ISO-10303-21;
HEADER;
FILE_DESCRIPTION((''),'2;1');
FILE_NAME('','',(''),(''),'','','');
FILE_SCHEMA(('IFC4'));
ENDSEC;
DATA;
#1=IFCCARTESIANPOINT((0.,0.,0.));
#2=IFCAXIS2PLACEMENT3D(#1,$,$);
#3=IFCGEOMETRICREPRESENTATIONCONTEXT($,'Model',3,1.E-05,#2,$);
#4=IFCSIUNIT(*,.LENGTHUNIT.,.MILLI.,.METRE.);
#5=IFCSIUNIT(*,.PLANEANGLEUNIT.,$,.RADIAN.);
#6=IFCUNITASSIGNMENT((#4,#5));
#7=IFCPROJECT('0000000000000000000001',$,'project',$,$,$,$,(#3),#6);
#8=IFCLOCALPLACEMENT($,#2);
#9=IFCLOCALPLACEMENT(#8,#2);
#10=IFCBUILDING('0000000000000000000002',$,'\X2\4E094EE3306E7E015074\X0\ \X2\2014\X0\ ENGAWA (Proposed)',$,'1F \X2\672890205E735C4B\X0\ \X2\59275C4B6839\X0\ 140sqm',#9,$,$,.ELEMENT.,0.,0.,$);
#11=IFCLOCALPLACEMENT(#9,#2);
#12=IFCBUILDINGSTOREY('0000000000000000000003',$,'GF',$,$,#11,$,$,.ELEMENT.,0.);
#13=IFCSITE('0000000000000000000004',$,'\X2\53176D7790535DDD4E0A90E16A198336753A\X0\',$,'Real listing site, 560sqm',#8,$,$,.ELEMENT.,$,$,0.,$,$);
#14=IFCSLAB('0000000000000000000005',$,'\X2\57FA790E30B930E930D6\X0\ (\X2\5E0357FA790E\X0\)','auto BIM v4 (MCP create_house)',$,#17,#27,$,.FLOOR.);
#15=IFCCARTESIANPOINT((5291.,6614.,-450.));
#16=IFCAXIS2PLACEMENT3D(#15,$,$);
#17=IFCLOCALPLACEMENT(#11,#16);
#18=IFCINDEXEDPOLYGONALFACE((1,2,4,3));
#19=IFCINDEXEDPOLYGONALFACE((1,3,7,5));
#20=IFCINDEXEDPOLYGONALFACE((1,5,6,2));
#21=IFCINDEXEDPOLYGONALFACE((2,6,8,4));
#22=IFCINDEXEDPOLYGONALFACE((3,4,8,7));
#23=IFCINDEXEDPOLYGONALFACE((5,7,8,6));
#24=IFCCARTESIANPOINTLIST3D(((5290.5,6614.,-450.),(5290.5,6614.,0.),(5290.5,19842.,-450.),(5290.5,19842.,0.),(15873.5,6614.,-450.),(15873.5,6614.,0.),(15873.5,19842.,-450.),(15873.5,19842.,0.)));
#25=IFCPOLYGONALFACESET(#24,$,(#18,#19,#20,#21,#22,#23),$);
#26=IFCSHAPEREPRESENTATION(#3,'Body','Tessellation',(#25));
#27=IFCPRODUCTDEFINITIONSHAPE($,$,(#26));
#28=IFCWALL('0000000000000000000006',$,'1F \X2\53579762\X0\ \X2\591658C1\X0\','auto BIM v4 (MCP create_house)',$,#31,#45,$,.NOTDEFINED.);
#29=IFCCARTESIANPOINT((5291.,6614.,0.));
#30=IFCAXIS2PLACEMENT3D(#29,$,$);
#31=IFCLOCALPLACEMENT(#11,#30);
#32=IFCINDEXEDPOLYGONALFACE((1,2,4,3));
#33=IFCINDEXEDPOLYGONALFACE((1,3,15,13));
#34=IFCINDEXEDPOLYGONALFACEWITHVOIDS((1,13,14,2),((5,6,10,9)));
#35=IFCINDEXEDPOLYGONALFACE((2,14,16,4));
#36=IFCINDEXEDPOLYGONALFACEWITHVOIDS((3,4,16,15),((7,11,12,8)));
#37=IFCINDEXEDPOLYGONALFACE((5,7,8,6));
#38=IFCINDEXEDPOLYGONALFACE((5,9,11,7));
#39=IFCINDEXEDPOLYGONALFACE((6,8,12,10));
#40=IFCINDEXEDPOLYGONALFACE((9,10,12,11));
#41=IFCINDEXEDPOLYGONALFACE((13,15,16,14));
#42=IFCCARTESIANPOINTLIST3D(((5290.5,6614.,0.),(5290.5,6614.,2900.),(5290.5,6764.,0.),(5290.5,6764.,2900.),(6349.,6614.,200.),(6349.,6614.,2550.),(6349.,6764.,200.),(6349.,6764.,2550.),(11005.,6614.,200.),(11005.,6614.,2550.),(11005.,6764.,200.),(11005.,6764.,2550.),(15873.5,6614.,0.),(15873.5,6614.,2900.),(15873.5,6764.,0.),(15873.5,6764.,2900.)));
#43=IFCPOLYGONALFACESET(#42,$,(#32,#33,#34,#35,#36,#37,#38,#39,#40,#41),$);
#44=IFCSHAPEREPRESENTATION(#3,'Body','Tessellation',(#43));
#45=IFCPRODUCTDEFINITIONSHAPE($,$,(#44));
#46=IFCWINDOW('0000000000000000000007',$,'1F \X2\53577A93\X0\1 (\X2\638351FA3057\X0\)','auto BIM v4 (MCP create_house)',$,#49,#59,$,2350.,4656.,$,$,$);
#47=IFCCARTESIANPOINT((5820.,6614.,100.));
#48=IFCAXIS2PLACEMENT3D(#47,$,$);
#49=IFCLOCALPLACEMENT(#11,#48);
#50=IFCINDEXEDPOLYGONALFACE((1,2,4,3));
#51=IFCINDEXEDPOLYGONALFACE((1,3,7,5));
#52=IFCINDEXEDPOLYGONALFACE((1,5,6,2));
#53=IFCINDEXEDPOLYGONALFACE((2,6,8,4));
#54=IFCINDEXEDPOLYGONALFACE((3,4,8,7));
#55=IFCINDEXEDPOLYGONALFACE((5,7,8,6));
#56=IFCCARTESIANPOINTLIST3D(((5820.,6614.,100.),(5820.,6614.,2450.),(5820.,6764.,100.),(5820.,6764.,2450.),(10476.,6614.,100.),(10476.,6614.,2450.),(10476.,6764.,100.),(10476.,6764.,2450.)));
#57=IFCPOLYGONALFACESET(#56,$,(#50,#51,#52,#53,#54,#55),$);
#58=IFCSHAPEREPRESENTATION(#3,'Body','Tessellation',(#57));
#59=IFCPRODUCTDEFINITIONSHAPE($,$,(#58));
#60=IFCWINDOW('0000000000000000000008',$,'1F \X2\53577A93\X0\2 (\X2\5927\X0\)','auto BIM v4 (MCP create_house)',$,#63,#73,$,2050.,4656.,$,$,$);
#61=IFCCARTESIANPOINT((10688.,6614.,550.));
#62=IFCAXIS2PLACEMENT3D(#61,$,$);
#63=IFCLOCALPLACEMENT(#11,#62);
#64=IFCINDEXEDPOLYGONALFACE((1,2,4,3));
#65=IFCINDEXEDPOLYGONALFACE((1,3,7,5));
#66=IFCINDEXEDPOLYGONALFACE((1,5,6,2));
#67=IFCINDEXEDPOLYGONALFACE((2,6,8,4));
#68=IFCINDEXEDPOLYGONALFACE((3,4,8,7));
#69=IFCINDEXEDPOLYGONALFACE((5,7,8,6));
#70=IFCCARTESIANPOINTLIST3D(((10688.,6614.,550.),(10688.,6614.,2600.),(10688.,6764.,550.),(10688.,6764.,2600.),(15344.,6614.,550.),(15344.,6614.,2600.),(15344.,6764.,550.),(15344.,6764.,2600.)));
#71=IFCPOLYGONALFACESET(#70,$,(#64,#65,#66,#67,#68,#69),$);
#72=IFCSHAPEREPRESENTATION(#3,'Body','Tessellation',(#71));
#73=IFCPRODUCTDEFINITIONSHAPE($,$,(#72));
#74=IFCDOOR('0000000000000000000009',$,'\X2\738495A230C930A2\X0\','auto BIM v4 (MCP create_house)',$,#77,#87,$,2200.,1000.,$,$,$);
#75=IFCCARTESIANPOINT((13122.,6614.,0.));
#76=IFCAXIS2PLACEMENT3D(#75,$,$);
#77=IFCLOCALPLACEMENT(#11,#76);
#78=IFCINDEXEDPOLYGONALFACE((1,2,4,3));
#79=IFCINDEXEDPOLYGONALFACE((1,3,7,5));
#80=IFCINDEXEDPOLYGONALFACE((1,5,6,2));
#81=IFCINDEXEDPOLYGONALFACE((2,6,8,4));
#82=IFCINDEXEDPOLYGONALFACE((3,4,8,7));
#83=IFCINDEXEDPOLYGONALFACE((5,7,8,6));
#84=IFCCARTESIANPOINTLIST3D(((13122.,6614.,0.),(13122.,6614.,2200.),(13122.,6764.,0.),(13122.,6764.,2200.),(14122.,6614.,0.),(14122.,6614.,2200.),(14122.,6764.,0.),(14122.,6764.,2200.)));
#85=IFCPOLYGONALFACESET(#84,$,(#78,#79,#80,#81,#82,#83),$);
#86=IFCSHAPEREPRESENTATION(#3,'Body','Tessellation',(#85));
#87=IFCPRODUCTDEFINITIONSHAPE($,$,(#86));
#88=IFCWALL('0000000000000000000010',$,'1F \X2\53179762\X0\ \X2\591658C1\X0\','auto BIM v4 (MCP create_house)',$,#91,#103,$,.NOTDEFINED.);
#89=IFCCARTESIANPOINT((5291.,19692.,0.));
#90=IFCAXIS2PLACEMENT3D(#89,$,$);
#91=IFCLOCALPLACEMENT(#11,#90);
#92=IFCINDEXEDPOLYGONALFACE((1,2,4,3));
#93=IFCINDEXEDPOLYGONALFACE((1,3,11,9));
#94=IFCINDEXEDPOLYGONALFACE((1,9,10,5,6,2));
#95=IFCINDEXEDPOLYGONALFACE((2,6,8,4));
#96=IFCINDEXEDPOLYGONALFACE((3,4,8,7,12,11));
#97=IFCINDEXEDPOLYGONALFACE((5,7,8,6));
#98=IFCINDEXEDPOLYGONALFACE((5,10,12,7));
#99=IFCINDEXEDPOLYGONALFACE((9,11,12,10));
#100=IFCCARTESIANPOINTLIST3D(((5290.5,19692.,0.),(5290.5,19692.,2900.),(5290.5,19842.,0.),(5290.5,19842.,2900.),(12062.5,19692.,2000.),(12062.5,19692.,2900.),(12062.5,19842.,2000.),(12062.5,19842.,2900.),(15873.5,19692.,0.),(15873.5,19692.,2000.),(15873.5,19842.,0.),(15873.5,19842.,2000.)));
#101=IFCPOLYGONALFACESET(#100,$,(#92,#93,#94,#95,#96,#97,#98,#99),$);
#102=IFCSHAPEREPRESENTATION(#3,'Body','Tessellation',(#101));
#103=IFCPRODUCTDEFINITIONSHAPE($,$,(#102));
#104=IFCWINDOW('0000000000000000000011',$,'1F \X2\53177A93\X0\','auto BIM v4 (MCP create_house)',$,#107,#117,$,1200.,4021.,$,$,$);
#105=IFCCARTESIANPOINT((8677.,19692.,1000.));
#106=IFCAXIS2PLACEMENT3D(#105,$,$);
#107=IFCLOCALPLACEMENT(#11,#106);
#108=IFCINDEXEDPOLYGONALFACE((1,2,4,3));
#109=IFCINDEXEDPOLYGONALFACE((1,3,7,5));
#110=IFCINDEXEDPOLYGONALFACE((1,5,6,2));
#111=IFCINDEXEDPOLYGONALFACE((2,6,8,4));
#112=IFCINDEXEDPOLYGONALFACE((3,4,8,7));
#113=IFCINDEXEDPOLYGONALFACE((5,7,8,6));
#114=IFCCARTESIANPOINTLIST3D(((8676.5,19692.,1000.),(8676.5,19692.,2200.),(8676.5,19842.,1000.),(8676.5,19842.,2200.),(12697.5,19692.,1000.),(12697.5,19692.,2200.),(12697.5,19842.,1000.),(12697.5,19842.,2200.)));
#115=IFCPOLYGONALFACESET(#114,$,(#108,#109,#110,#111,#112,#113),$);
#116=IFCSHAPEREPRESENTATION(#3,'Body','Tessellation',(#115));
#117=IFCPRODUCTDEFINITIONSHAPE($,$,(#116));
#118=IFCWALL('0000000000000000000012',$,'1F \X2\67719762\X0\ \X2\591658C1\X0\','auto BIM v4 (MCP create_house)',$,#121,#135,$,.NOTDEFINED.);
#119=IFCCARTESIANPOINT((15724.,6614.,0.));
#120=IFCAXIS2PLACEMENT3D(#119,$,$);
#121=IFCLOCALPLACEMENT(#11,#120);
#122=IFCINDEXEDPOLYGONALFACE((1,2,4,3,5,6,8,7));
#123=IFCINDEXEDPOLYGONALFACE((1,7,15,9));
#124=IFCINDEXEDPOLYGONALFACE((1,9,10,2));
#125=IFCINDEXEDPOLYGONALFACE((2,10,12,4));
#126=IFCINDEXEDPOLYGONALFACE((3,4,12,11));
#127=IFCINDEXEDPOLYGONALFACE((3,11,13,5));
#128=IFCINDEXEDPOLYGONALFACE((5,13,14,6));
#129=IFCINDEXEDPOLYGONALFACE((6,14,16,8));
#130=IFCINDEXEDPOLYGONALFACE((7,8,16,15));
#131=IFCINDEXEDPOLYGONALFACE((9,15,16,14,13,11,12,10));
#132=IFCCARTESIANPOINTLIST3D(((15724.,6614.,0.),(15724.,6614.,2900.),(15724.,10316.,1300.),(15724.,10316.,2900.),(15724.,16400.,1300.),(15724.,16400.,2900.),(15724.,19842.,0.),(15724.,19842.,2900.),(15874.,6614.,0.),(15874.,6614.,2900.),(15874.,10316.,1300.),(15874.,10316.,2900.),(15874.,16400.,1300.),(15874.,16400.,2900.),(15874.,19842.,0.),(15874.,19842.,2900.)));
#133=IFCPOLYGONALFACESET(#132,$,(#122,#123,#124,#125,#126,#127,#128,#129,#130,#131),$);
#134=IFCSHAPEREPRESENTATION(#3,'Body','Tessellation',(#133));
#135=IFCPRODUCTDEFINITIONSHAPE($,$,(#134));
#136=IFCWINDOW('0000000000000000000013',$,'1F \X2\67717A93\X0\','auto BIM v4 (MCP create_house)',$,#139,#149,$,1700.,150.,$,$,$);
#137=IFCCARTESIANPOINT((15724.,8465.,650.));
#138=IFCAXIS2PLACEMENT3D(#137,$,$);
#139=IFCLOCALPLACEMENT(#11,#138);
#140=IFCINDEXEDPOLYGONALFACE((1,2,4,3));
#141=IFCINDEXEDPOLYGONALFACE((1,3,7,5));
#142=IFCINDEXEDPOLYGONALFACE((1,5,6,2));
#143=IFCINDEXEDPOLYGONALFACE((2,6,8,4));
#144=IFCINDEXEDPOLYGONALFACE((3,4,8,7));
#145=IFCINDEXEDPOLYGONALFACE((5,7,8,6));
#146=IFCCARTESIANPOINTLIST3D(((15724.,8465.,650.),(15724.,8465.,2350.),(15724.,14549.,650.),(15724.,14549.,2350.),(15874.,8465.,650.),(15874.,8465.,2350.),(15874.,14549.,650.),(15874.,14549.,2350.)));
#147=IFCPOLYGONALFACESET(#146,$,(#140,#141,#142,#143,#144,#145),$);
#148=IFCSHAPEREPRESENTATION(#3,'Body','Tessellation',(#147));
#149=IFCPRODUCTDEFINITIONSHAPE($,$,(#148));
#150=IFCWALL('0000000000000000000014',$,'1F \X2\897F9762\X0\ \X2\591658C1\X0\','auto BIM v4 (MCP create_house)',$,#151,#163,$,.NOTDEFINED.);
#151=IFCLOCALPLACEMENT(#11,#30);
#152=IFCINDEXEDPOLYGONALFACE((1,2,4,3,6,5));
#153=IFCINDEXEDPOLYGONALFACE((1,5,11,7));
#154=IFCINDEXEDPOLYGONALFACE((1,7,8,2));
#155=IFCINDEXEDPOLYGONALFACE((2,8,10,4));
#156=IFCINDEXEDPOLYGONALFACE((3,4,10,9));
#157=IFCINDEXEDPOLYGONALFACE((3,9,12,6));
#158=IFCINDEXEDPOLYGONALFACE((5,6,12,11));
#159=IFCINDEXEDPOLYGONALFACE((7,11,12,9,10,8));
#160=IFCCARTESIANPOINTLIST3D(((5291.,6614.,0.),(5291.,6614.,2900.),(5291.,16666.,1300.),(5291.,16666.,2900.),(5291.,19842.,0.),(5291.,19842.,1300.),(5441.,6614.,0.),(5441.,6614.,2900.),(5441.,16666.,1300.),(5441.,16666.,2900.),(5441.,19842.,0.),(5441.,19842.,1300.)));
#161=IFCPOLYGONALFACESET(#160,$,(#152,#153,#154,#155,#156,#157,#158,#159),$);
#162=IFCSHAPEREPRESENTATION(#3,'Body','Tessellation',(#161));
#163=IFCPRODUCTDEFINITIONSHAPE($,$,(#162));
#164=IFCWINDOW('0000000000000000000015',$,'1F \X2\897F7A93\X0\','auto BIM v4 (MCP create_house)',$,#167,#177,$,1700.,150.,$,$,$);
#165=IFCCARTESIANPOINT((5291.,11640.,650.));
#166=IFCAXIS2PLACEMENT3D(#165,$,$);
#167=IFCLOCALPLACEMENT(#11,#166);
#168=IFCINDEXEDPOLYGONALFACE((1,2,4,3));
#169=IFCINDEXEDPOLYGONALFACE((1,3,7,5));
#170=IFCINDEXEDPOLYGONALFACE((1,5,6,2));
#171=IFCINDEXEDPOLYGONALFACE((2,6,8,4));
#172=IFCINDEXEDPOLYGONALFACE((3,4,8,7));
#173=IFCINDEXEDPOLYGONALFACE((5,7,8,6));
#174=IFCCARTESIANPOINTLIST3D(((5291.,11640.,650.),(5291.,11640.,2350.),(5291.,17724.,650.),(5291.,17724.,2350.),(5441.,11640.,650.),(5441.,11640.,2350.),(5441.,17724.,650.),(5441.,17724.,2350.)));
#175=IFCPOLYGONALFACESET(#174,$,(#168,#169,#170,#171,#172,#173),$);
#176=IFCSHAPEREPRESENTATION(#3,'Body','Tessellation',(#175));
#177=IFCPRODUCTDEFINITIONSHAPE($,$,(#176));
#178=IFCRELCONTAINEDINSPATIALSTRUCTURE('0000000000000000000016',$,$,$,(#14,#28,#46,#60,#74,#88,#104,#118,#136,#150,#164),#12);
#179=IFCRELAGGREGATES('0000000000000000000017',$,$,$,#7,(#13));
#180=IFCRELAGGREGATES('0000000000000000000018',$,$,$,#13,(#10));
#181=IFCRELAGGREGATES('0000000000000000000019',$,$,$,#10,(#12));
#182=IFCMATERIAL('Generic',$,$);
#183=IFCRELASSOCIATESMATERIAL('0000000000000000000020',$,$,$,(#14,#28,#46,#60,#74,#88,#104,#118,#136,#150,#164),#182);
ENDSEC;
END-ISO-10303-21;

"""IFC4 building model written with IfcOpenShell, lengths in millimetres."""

from ifc_helpers import new_model, si_unit, frame, frame_2d, origin, place, context, project, spatial, rectangle, extrude, material, element, fill, save


model = new_model("IFC4")

# Units and contexts
model_context = context("Model", 3, precision=1e-05, world=origin())
ifc_project = project(units=[si_unit("LENGTHUNIT", "METRE", prefix="MILLI"), si_unit("PLANEANGLEUNIT", "RADIAN")], contexts=[model_context])

# Site, building, storey
site_placement = place(None, origin())
site = spatial("IfcSite", under=ifc_project, at=site_placement, Name="北海道川上郡標茶町", ObjectType="Real listing site, 560sqm", CompositionType="ELEMENT", RefElevation=0.0)
building_placement = place(site_placement, origin())
building = spatial("IfcBuilding", under=site, at=building_placement, Name="三代の縁側 — ENGAWA (Proposed)", ObjectType="1F 木造平屋 大屋根 140sqm", CompositionType="ELEMENT", ElevationOfRefHeight=0.0, ElevationOfTerrain=0.0)
storey_placement = place(building_placement, origin())
storey = spatial("IfcBuildingStorey", under=building, at=storey_placement, Name="GF", CompositionType="ELEMENT", Elevation=0.0)

# Slab
ifc_material = material(Name="Generic")
slab_1_placement = place(storey_placement, frame((5291.0, 6614.0, -450.0)))
element("IfcSlab", 1, at=slab_1_placement, inside=storey, material=ifc_material, Name="基礎スラブ (布基礎)", Description="auto BIM v4 (MCP create_house)", PredefinedType="FLOOR", context=model_context, shape_type="SweptSolid", body=[
    extrude(rectangle(XDim=10583.0, YDim=13228.0, at=frame_2d((5291.0, 6614.0))), frame((5291.0, 6614.0, -450.0)), (0.0, 0.0, 1.0), 450.0),
])

# Wall, openings, windows, door
wall_1_placement = place(storey_placement, frame((5291.0, 6614.0, 0.0)))
wall_1 = element("IfcWall", 2, at=wall_1_placement, inside=storey, material=ifc_material, Name="1F 南面 外壁", Description="auto BIM v4 (MCP create_house)", PredefinedType="NOTDEFINED", context=model_context, shape_type="SweptSolid", body=[
    extrude(rectangle(XDim=10583.0, YDim=150.0, at=frame_2d((5291.0, 75.0))), frame((5291.0, 6614.0, 0.0)), (0.0, 0.0, 1.0), 2900.0),
])
opening_1_placement = place(storey_placement, frame((5820.0, 6614.0, 100.0)))
opening_1 = element("IfcOpeningElement", 3, at=opening_1_placement, cuts=wall_1, PredefinedType="NOTDEFINED", context=model_context, shape_type="SweptSolid", body=[
    extrude(rectangle(XDim=4656.0, YDim=150.0, at=frame_2d((2328.0, 75.0))), frame((5820.0, 6614.0, 100.0)), (0.0, 0.0, 1.0), 2350.0),
])
opening_2_placement = place(storey_placement, frame((10688.0, 6614.0, 550.0)))
opening_2 = element("IfcOpeningElement", 4, at=opening_2_placement, cuts=wall_1, PredefinedType="NOTDEFINED", context=model_context, shape_type="SweptSolid", body=[
    extrude(rectangle(XDim=4656.0, YDim=150.0, at=frame_2d((2328.0, 75.0))), frame((10688.0, 6614.0, 550.0)), (0.0, 0.0, 1.0), 2050.0),
])
opening_3_placement = place(storey_placement, frame((13122.0, 6614.0, 0.0)))
opening_3 = element("IfcOpeningElement", 5, at=opening_3_placement, cuts=wall_1, PredefinedType="NOTDEFINED", context=model_context, shape_type="SweptSolid", body=[
    extrude(rectangle(XDim=1000.0, YDim=150.0, at=frame_2d((500.0, 75.0))), frame((13122.0, 6614.0, 0.0)), (0.0, 0.0, 1.0), 2200.0),
])
window_1_placement = place(storey_placement, frame((5820.0, 6614.0, 100.0)))
window_1 = element("IfcWindow", 6, at=window_1_placement, inside=storey, material=ifc_material, Name="1F 南窓1 (掃出し)", Description="auto BIM v4 (MCP create_house)", OverallHeight=2350.0, OverallWidth=4656.0, context=model_context, shape_type="SweptSolid", body=[
    extrude(rectangle(XDim=4656.0, YDim=150.0, at=frame_2d((2328.0, 75.0))), frame((5820.0, 6614.0, 100.0)), (0.0, 0.0, 1.0), 2350.0),
])
fill(opening_1, window_1)
window_2_placement = place(storey_placement, frame((10688.0, 6614.0, 550.0)))
window_2 = element("IfcWindow", 7, at=window_2_placement, inside=storey, material=ifc_material, Name="1F 南窓2 (大)", Description="auto BIM v4 (MCP create_house)", OverallHeight=2050.0, OverallWidth=4656.0, context=model_context, shape_type="SweptSolid", body=[
    extrude(rectangle(XDim=4656.0, YDim=150.0, at=frame_2d((2328.0, 75.0))), frame((10688.0, 6614.0, 550.0)), (0.0, 0.0, 1.0), 2050.0),
])
fill(opening_2, window_2)
door_placement = place(storey_placement, frame((13122.0, 6614.0, 0.0)))
door = element("IfcDoor", 8, at=door_placement, inside=storey, material=ifc_material, Name="玄関ドア", Description="auto BIM v4 (MCP create_house)", OverallHeight=2200.0, OverallWidth=1000.0, context=model_context, shape_type="SweptSolid", body=[
    extrude(rectangle(XDim=1000.0, YDim=150.0, at=frame_2d((500.0, 75.0))), frame((13122.0, 6614.0, 0.0)), (0.0, 0.0, 1.0), 2200.0),
])
fill(opening_3, door)

# Walls, openings, windows
wall_2_placement = place(storey_placement, frame((5291.0, 19692.0, 0.0)))
wall_2 = element("IfcWall", 9, at=wall_2_placement, inside=storey, material=ifc_material, Name="1F 北面 外壁", Description="auto BIM v4 (MCP create_house)", PredefinedType="NOTDEFINED", context=model_context, shape_type="SweptSolid", body=[
    extrude(rectangle(XDim=10583.0, YDim=150.0, at=frame_2d((5291.0, 75.0))), frame((5291.0, 19692.0, 0.0)), (0.0, 0.0, 1.0), 2900.0),
])
opening_4_placement = place(storey_placement, frame((8677.0, 19692.0, 1000.0)))
opening_4 = element("IfcOpeningElement", 10, at=opening_4_placement, cuts=wall_2, PredefinedType="NOTDEFINED", context=model_context, shape_type="SweptSolid", body=[
    extrude(rectangle(XDim=4021.0, YDim=150.0, at=frame_2d((2010.0, 75.0))), frame((8677.0, 19692.0, 1000.0)), (0.0, 0.0, 1.0), 1200.0),
])
window_3_placement = place(storey_placement, frame((8677.0, 19692.0, 1000.0)))
window_3 = element("IfcWindow", 11, at=window_3_placement, inside=storey, material=ifc_material, Name="1F 北窓", Description="auto BIM v4 (MCP create_house)", OverallHeight=1200.0, OverallWidth=4021.0, context=model_context, shape_type="SweptSolid", body=[
    extrude(rectangle(XDim=4021.0, YDim=150.0, at=frame_2d((2010.0, 75.0))), frame((8677.0, 19692.0, 1000.0)), (0.0, 0.0, 1.0), 1200.0),
])
fill(opening_4, window_3)
wall_3_placement = place(storey_placement, frame((15724.0, 6614.0, 0.0)))
wall_3 = element("IfcWall", 12, at=wall_3_placement, inside=storey, material=ifc_material, Name="1F 東面 外壁", Description="auto BIM v4 (MCP create_house)", PredefinedType="NOTDEFINED", context=model_context, shape_type="SweptSolid", body=[
    extrude(rectangle(XDim=150.0, YDim=13228.0, at=frame_2d((75.0, 6614.0))), frame((15724.0, 6614.0, 0.0)), (0.0, 0.0, 1.0), 2900.0),
])
opening_5_placement = place(storey_placement, frame((15724.0, 8465.0, 650.0)))
opening_5 = element("IfcOpeningElement", 13, at=opening_5_placement, cuts=wall_3, PredefinedType="NOTDEFINED", context=model_context, shape_type="SweptSolid", body=[
    extrude(rectangle(XDim=150.0, YDim=6084.0, at=frame_2d((75.0, 3042.0))), frame((15724.0, 8465.0, 650.0)), (0.0, 0.0, 1.0), 1700.0),
])
window_4_placement = place(storey_placement, frame((15724.0, 8465.0, 650.0)))
window_4 = element("IfcWindow", 14, at=window_4_placement, inside=storey, material=ifc_material, Name="1F 東窓", Description="auto BIM v4 (MCP create_house)", OverallHeight=1700.0, OverallWidth=150.0, context=model_context, shape_type="SweptSolid", body=[
    extrude(rectangle(XDim=150.0, YDim=6084.0, at=frame_2d((75.0, 3042.0))), frame((15724.0, 8465.0, 650.0)), (0.0, 0.0, 1.0), 1700.0),
])
fill(opening_5, window_4)
wall_4_placement = place(storey_placement, frame((5291.0, 6614.0, 0.0)))
wall_4 = element("IfcWall", 15, at=wall_4_placement, inside=storey, material=ifc_material, Name="1F 西面 外壁", Description="auto BIM v4 (MCP create_house)", PredefinedType="NOTDEFINED", context=model_context, shape_type="SweptSolid", body=[
    extrude(rectangle(XDim=150.0, YDim=13228.0, at=frame_2d((75.0, 6614.0))), frame((5291.0, 6614.0, 0.0)), (0.0, 0.0, 1.0), 2900.0),
])
opening_6_placement = place(storey_placement, frame((5291.0, 11640.0, 650.0)))
opening_6 = element("IfcOpeningElement", 16, at=opening_6_placement, cuts=wall_4, PredefinedType="NOTDEFINED", context=model_context, shape_type="SweptSolid", body=[
    extrude(rectangle(XDim=150.0, YDim=6084.0, at=frame_2d((75.0, 3042.0))), frame((5291.0, 11640.0, 650.0)), (0.0, 0.0, 1.0), 1700.0),
])
window_5_placement = place(storey_placement, frame((5291.0, 11640.0, 650.0)))
window_5 = element("IfcWindow", 17, at=window_5_placement, inside=storey, material=ifc_material, Name="1F 西窓", Description="auto BIM v4 (MCP create_house)", OverallHeight=1700.0, OverallWidth=150.0, context=model_context, shape_type="SweptSolid", body=[
    extrude(rectangle(XDim=150.0, YDim=6084.0, at=frame_2d((75.0, 3042.0))), frame((5291.0, 11640.0, 650.0)), (0.0, 0.0, 1.0), 1700.0),
])
fill(opening_6, window_5)

save(model, "model.ifc")
